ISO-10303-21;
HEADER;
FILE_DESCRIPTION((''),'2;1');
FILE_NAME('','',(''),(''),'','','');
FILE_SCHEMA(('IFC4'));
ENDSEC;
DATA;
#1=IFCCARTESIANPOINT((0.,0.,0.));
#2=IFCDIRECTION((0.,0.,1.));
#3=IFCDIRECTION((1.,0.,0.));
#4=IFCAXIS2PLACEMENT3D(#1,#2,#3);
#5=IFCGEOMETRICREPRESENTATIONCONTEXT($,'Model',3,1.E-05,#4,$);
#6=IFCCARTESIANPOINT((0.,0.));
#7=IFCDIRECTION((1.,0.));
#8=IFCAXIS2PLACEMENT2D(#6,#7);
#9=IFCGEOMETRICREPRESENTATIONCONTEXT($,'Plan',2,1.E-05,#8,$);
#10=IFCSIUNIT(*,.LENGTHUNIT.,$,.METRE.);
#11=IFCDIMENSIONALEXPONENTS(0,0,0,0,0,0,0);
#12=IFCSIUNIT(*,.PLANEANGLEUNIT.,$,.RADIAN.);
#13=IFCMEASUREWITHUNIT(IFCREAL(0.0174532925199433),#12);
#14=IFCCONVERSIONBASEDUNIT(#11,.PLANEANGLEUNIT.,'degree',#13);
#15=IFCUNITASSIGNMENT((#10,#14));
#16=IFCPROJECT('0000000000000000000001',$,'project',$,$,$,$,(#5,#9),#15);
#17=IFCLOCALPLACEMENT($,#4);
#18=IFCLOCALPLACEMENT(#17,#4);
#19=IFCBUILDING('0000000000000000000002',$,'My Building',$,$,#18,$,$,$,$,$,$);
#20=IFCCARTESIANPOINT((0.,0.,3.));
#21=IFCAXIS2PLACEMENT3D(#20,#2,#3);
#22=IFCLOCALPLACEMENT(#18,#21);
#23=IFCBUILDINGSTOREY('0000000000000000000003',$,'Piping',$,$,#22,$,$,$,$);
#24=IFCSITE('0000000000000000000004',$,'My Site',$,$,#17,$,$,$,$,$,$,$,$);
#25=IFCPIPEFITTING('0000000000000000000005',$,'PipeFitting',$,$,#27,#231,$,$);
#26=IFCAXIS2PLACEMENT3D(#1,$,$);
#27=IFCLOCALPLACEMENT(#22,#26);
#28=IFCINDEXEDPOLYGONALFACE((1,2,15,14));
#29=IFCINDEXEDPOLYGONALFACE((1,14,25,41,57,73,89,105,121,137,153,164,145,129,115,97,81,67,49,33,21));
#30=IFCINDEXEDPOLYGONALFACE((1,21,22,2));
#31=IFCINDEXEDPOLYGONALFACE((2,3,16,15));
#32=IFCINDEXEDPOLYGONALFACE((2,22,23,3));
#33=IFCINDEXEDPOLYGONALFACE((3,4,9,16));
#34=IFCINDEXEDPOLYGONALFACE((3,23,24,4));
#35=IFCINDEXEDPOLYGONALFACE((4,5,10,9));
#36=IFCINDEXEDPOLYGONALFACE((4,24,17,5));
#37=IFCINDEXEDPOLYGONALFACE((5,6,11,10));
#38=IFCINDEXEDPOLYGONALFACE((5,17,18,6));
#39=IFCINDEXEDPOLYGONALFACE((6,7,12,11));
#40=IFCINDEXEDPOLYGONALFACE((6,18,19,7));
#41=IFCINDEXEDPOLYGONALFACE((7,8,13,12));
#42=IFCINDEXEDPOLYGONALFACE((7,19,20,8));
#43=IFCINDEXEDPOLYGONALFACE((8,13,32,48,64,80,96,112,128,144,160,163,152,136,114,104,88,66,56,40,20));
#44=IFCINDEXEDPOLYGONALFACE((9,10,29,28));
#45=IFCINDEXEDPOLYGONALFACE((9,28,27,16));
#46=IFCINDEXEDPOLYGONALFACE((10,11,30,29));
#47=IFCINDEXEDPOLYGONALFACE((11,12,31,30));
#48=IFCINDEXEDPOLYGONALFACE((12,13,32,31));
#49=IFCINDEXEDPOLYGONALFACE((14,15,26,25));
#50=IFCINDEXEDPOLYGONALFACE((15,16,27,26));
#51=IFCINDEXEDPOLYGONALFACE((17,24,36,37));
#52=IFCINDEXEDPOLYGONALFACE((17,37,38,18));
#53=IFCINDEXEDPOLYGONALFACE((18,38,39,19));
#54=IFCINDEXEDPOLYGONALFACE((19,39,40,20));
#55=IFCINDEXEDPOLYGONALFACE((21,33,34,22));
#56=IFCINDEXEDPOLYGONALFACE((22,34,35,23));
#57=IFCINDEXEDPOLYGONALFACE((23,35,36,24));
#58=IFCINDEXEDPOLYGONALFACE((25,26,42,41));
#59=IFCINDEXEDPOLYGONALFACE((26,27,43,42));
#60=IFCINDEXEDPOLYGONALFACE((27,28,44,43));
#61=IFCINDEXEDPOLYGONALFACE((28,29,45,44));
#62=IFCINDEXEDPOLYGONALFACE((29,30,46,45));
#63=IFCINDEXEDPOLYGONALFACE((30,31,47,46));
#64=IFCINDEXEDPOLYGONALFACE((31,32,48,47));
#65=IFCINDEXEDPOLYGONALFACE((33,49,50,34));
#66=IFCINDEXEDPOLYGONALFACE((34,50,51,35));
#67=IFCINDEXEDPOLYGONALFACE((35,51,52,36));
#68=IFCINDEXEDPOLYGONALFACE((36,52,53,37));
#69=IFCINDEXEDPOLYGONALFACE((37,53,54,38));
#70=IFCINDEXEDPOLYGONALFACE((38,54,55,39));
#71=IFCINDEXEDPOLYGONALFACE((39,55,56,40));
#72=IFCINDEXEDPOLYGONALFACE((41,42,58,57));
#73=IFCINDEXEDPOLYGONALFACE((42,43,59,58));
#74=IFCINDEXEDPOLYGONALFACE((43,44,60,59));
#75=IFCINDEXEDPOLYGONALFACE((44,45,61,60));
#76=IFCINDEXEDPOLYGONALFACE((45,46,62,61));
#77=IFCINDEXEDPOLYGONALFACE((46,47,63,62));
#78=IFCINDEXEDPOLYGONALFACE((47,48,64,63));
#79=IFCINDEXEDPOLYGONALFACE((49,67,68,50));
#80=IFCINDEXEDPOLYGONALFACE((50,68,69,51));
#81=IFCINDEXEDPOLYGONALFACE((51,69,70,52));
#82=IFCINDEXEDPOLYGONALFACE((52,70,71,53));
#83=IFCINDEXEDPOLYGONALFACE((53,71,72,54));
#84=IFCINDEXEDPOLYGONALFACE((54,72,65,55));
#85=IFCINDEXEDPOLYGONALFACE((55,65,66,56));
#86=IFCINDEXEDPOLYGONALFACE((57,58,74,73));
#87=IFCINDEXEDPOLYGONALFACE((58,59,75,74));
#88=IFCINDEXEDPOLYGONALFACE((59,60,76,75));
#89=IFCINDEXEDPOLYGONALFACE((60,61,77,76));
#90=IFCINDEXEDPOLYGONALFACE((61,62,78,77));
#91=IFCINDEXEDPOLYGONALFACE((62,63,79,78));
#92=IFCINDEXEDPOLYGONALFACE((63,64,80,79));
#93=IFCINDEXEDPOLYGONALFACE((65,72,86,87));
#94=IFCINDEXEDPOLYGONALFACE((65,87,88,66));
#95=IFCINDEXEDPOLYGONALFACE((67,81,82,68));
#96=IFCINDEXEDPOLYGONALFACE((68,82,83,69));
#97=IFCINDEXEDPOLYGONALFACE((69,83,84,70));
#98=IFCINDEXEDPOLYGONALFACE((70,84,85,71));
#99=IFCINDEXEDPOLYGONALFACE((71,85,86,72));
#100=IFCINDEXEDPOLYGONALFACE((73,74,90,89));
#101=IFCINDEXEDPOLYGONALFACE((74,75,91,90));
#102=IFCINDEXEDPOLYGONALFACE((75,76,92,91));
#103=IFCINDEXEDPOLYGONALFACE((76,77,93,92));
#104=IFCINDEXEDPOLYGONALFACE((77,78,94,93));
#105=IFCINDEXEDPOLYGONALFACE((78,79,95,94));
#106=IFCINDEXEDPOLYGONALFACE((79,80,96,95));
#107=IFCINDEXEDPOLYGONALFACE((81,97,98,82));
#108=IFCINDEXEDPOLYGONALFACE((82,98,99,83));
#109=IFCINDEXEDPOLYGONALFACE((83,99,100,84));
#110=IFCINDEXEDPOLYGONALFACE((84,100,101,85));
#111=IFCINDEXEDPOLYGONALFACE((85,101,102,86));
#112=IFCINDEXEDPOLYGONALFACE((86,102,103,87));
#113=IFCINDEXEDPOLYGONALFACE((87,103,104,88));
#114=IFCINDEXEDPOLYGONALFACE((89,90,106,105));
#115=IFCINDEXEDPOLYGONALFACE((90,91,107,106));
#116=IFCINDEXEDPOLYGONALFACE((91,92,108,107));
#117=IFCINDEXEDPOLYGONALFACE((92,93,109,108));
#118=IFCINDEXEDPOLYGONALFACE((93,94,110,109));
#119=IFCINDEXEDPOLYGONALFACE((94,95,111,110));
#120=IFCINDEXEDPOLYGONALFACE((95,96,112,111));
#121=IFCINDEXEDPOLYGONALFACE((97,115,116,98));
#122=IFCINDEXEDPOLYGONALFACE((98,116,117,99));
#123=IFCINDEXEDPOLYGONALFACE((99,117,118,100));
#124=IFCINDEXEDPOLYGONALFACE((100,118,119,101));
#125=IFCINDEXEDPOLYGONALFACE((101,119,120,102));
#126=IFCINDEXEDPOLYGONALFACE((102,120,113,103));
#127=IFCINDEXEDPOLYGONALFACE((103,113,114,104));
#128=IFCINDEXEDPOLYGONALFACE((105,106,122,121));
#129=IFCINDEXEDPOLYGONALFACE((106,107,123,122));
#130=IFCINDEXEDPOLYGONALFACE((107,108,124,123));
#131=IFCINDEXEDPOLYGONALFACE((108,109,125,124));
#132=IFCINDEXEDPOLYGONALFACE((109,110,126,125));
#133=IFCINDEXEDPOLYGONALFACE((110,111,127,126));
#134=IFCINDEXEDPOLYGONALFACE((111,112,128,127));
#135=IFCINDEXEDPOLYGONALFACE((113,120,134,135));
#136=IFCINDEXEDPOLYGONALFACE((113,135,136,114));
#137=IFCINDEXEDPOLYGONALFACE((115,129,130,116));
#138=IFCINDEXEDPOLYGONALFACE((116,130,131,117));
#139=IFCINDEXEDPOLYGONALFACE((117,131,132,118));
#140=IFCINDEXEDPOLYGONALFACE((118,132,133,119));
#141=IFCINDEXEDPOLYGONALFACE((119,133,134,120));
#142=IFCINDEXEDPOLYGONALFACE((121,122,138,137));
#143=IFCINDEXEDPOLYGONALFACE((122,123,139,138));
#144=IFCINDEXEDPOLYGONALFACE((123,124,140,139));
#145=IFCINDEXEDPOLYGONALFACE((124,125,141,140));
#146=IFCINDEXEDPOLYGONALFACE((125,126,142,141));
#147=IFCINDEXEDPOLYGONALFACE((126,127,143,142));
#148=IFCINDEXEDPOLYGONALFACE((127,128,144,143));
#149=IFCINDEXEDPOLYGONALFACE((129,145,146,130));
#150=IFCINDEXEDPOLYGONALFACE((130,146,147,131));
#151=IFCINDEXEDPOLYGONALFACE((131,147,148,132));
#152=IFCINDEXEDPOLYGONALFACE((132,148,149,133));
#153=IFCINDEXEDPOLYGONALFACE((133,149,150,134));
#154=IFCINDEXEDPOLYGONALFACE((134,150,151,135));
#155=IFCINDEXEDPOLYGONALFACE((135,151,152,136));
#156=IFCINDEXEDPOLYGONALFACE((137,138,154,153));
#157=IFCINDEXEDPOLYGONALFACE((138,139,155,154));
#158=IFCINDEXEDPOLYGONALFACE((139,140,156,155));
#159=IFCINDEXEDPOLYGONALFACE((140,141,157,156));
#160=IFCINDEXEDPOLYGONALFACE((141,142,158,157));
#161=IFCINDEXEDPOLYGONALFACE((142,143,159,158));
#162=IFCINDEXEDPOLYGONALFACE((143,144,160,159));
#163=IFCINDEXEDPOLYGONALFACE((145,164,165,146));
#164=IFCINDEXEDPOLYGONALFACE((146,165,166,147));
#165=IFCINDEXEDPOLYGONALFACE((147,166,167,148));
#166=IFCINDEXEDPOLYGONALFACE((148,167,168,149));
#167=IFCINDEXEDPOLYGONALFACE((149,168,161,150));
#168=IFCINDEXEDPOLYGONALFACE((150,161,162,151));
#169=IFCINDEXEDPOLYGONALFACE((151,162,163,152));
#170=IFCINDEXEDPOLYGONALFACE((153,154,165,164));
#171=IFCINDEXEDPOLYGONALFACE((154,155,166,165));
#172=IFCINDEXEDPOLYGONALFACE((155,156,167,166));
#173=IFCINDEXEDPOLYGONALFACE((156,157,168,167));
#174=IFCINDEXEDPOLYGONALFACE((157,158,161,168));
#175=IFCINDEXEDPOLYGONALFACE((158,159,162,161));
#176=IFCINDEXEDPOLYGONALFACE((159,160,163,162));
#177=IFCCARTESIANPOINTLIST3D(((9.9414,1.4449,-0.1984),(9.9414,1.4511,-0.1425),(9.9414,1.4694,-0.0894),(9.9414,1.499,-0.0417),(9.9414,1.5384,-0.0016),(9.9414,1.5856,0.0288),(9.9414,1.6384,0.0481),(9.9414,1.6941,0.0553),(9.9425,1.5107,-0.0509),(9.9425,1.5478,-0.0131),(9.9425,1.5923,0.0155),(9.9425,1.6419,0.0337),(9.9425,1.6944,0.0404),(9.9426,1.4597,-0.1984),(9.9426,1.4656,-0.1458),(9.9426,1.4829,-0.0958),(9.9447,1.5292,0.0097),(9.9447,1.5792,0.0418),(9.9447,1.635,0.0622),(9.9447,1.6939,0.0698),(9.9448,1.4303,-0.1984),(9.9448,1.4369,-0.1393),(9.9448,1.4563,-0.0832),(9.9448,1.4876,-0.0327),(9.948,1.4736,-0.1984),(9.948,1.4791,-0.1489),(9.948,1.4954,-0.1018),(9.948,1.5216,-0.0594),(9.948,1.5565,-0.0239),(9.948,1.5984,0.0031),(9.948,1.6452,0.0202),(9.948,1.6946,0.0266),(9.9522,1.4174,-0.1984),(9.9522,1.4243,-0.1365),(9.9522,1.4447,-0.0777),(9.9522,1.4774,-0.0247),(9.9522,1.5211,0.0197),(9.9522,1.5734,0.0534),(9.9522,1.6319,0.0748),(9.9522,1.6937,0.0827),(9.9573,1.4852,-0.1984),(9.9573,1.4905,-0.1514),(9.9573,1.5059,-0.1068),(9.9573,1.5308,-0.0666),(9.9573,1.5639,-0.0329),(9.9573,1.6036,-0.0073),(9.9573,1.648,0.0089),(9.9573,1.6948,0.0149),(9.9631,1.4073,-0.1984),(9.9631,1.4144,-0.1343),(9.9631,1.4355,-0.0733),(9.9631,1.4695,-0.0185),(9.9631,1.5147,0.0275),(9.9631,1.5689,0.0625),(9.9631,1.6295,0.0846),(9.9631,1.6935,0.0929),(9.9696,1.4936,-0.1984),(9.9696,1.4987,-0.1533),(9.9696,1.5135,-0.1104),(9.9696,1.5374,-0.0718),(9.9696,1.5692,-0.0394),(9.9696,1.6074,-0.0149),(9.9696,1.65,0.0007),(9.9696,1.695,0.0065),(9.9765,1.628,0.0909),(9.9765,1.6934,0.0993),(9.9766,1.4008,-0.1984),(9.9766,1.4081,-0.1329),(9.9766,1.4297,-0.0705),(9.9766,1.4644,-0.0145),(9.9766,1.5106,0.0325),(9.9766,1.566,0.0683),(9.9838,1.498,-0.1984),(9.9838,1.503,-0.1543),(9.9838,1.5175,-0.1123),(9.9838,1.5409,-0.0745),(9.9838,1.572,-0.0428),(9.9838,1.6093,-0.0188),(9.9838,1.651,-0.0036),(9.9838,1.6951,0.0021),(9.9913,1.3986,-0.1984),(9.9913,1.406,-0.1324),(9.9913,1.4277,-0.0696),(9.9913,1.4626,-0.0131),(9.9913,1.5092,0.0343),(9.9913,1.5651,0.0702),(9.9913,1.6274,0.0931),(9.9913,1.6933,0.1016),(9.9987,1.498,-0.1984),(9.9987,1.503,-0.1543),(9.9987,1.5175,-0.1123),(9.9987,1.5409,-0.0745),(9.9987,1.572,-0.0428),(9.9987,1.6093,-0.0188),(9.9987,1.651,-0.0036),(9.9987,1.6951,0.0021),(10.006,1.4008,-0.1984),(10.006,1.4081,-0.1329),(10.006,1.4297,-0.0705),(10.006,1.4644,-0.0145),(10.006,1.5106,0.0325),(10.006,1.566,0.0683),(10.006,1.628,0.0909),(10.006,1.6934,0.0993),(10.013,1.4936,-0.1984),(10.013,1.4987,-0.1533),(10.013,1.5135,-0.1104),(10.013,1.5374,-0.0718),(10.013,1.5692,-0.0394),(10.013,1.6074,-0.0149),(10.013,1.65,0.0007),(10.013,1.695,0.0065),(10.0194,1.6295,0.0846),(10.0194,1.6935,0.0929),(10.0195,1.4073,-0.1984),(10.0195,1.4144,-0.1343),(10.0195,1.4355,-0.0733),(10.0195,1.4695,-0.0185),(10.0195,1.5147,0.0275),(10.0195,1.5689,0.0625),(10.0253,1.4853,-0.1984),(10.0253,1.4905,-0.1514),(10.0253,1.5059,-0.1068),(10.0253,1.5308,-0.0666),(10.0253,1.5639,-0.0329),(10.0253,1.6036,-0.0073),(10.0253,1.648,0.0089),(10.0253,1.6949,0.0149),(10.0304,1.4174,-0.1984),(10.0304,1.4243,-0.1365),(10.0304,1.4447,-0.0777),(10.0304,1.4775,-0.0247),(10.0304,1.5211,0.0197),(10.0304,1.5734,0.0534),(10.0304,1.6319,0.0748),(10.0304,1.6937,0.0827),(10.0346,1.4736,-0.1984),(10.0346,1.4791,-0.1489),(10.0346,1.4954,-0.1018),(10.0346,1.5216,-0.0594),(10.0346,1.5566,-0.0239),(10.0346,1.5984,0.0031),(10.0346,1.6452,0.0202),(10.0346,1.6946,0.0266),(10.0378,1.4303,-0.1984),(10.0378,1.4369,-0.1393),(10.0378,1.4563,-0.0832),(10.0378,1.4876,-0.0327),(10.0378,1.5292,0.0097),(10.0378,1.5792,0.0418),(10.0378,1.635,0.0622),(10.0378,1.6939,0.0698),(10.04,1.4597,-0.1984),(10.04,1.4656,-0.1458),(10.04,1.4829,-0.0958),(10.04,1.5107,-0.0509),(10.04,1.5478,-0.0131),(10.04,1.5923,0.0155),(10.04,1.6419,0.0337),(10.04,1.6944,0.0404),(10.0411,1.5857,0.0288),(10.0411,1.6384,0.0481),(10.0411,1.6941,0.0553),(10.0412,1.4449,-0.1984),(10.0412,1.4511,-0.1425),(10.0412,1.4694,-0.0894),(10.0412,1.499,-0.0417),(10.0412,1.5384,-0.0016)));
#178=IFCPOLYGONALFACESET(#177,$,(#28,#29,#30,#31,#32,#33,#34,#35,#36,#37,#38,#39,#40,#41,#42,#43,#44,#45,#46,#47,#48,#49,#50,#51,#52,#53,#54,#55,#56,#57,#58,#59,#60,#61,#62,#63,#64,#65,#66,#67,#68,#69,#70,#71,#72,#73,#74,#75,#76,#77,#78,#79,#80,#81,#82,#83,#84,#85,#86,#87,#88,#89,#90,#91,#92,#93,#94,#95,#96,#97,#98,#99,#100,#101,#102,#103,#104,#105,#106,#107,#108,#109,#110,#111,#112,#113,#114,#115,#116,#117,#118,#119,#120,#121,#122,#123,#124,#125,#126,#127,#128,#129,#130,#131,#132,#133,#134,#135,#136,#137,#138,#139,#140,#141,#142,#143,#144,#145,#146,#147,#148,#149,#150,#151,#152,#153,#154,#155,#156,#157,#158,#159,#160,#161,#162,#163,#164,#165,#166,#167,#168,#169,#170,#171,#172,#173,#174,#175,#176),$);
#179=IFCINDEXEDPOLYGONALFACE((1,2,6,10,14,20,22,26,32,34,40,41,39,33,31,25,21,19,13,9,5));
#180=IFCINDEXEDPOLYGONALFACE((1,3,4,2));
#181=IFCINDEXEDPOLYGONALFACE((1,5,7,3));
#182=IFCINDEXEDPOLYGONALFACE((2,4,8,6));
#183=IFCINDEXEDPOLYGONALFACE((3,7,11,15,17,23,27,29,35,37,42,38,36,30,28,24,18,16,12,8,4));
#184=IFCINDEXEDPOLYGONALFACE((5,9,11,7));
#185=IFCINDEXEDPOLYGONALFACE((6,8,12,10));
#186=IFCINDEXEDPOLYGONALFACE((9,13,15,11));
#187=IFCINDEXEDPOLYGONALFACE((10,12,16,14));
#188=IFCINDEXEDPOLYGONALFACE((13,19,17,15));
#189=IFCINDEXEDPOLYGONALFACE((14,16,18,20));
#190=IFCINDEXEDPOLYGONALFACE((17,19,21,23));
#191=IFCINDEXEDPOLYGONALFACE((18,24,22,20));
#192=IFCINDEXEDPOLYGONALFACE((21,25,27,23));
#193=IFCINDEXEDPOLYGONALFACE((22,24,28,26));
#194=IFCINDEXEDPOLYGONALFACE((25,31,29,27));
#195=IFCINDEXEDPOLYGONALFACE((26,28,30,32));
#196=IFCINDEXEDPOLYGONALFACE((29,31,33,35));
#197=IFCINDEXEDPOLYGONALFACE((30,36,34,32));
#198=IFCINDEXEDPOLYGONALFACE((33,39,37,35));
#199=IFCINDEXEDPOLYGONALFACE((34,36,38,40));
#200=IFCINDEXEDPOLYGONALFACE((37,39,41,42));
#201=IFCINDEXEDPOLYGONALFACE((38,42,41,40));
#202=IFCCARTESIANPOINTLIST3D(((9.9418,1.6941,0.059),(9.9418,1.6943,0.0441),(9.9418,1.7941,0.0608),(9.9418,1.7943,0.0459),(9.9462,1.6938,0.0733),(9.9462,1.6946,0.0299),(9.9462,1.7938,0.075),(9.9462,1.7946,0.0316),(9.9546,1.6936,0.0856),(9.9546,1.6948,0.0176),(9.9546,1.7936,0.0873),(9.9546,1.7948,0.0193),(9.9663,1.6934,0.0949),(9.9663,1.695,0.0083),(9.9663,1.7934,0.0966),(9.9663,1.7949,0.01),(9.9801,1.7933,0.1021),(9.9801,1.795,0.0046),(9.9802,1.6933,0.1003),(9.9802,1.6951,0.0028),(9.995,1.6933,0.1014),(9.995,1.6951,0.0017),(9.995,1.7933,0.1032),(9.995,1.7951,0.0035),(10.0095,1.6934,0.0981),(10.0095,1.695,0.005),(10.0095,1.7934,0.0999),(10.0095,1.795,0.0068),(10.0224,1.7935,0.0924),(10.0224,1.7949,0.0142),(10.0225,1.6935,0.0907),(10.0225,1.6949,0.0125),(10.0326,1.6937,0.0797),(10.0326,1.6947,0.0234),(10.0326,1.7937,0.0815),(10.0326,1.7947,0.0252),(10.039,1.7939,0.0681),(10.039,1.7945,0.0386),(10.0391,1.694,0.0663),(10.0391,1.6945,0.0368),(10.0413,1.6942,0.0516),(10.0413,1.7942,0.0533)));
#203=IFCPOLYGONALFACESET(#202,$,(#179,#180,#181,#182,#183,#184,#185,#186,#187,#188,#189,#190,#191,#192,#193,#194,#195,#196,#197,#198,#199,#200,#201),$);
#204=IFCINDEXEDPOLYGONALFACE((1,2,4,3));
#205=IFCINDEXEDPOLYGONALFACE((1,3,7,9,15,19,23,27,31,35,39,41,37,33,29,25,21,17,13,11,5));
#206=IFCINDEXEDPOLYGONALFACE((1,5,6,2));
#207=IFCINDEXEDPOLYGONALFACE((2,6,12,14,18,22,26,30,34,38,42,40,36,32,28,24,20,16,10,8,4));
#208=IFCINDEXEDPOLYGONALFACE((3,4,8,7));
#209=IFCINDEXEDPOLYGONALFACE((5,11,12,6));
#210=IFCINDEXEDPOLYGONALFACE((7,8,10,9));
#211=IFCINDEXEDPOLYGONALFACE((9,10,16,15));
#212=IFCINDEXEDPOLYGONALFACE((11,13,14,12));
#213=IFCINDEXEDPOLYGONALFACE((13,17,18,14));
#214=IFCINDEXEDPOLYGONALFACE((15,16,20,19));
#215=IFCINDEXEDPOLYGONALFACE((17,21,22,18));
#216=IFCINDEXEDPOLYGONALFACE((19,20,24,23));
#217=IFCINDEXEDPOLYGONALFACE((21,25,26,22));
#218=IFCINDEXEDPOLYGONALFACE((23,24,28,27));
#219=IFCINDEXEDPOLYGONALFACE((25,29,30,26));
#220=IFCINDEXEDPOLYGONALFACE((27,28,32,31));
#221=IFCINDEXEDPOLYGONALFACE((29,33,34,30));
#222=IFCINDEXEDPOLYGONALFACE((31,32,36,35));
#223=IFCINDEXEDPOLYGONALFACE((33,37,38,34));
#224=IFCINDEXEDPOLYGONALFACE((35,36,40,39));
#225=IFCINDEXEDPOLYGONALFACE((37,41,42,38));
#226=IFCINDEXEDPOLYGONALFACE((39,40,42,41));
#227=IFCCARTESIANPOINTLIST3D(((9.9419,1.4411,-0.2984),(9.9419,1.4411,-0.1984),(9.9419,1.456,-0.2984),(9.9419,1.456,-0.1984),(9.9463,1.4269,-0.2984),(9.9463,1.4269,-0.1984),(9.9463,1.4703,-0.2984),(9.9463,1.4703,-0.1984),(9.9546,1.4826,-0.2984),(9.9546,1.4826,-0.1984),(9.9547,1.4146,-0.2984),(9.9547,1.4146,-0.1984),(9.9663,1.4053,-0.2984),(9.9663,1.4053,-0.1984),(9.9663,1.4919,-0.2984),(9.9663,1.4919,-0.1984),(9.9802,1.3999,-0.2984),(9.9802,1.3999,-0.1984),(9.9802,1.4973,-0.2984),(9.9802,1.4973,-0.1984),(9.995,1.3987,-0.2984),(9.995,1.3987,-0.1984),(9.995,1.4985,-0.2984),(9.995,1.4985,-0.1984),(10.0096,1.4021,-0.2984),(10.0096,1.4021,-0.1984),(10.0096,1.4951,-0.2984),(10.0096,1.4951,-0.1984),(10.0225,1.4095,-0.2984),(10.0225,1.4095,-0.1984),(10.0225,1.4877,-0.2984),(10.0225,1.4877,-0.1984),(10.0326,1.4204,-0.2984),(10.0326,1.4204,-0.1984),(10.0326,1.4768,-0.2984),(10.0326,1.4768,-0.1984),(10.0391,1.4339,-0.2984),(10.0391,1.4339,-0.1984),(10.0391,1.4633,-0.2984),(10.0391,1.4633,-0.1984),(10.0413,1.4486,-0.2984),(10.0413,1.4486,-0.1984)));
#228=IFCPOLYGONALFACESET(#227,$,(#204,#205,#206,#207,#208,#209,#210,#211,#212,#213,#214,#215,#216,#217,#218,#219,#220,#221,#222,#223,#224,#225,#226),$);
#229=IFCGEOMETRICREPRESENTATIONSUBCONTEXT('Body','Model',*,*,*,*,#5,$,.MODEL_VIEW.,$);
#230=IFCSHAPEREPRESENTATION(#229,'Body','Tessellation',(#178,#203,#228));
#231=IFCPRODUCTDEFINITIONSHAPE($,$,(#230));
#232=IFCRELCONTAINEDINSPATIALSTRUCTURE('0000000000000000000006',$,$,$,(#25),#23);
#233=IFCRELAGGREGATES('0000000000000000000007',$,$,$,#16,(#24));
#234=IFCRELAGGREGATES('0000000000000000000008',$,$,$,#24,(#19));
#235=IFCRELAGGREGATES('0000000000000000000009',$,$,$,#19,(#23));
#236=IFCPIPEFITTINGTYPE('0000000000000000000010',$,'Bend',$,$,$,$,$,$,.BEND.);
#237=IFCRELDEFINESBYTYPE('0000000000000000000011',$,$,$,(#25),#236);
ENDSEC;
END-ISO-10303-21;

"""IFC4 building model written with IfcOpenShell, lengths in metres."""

from ifc_helpers import new_model, entity, si_unit, converted_unit, frame, origin_with_axes, origin_2d_with_axis, place, context, subcontext, project, spatial, circle, extrude, source, transform, mapped, type_object, type_shapes, element, save


model = new_model("IFC4")

# Units and contexts
model_context = context("Model", 3, precision=1e-05, world=origin_with_axes())
plan_context = context("Plan", 2, precision=1e-05, world=origin_2d_with_axis())
body_context = subcontext(model_context, "Body", "Model", "MODEL_VIEW")
ifc_project = project(units=[si_unit("LENGTHUNIT", "METRE"), converted_unit("PLANEANGLEUNIT", "degree", entity("IfcReal", 0.0174532925199433), si_unit("PLANEANGLEUNIT", "RADIAN"), dimensions=[0, 0, 0, 0, 0, 0, 0])], contexts=[model_context, plan_context])

# Site, building, storey
site_placement = place(None, origin_with_axes())
site = spatial("IfcSite", under=ifc_project, at=site_placement, Name="My Site")
building_placement = place(site_placement, origin_with_axes())
building = spatial("IfcBuilding", under=site, at=building_placement, Name="My Building")
storey_placement = place(building_placement, frame((0.0, 0.0, 3.0), z_axis=(0.0, 0.0, 1.0), x_axis=(1.0, 0.0, 0.0)))
storey = spatial("IfcBuildingStorey", under=building, at=storey_placement, Name="Piping")

# Pipe fitting
pipe_fitting_type_1 = type_object("IfcPipeFittingType", Name="Bend", PredefinedType="BEND")
shared_shape_1 = source(origin_with_axes(), body_context, "Body", "SolidModel", [
    entity("IfcSweptDiskSolid", entity("IfcIndexedPolyCurve", entity("IfcCartesianPointList3D", [[0.0, 0.0, 0.1], [0.0, -0.0717, 0.2752], [0.0, -0.2456, 0.35]]), [entity("IfcArcIndex", [1, 2, 3])]), 0.05),
    extrude(circle(Radius=0.05), origin_with_axes(), (0.0, 0.0, 1.0), 0.1),
    extrude(circle(Radius=0.05), frame((0.0, -0.2456, 0.35), z_axis=(0.0, -0.999846, 0.017575), x_axis=(1.0, 0.0, 0.0)), (0.0, 0.0, 1.0), 0.1),
])
type_shapes(pipe_fitting_type_1, [shared_shape_1])
for number, where, z_axis, x_axis, name in (
    (1, (9.9913, 1.7942, 0.0533), (0.000099, -0.999846, -0.017575), (1.0, 0.000099, -0.000001), "PipeFitting"),
):
    element("IfcPipeFitting", number, at=place(storey_placement, frame(where, z_axis=z_axis, x_axis=x_axis)), inside=storey, type_object=pipe_fitting_type_1, Name=name, context=body_context, shape_type="MappedRepresentation", body=[
        mapped(shared_shape_1, transform((0.0, 0.0, 0.0), x_axis=(1.0, 0.0, 0.0), y_axis=(0.0, 1.0, 0.0), z_axis=(0.0, 0.0, 1.0), scale=1.0)),
    ])

save(model, "model.ifc")
